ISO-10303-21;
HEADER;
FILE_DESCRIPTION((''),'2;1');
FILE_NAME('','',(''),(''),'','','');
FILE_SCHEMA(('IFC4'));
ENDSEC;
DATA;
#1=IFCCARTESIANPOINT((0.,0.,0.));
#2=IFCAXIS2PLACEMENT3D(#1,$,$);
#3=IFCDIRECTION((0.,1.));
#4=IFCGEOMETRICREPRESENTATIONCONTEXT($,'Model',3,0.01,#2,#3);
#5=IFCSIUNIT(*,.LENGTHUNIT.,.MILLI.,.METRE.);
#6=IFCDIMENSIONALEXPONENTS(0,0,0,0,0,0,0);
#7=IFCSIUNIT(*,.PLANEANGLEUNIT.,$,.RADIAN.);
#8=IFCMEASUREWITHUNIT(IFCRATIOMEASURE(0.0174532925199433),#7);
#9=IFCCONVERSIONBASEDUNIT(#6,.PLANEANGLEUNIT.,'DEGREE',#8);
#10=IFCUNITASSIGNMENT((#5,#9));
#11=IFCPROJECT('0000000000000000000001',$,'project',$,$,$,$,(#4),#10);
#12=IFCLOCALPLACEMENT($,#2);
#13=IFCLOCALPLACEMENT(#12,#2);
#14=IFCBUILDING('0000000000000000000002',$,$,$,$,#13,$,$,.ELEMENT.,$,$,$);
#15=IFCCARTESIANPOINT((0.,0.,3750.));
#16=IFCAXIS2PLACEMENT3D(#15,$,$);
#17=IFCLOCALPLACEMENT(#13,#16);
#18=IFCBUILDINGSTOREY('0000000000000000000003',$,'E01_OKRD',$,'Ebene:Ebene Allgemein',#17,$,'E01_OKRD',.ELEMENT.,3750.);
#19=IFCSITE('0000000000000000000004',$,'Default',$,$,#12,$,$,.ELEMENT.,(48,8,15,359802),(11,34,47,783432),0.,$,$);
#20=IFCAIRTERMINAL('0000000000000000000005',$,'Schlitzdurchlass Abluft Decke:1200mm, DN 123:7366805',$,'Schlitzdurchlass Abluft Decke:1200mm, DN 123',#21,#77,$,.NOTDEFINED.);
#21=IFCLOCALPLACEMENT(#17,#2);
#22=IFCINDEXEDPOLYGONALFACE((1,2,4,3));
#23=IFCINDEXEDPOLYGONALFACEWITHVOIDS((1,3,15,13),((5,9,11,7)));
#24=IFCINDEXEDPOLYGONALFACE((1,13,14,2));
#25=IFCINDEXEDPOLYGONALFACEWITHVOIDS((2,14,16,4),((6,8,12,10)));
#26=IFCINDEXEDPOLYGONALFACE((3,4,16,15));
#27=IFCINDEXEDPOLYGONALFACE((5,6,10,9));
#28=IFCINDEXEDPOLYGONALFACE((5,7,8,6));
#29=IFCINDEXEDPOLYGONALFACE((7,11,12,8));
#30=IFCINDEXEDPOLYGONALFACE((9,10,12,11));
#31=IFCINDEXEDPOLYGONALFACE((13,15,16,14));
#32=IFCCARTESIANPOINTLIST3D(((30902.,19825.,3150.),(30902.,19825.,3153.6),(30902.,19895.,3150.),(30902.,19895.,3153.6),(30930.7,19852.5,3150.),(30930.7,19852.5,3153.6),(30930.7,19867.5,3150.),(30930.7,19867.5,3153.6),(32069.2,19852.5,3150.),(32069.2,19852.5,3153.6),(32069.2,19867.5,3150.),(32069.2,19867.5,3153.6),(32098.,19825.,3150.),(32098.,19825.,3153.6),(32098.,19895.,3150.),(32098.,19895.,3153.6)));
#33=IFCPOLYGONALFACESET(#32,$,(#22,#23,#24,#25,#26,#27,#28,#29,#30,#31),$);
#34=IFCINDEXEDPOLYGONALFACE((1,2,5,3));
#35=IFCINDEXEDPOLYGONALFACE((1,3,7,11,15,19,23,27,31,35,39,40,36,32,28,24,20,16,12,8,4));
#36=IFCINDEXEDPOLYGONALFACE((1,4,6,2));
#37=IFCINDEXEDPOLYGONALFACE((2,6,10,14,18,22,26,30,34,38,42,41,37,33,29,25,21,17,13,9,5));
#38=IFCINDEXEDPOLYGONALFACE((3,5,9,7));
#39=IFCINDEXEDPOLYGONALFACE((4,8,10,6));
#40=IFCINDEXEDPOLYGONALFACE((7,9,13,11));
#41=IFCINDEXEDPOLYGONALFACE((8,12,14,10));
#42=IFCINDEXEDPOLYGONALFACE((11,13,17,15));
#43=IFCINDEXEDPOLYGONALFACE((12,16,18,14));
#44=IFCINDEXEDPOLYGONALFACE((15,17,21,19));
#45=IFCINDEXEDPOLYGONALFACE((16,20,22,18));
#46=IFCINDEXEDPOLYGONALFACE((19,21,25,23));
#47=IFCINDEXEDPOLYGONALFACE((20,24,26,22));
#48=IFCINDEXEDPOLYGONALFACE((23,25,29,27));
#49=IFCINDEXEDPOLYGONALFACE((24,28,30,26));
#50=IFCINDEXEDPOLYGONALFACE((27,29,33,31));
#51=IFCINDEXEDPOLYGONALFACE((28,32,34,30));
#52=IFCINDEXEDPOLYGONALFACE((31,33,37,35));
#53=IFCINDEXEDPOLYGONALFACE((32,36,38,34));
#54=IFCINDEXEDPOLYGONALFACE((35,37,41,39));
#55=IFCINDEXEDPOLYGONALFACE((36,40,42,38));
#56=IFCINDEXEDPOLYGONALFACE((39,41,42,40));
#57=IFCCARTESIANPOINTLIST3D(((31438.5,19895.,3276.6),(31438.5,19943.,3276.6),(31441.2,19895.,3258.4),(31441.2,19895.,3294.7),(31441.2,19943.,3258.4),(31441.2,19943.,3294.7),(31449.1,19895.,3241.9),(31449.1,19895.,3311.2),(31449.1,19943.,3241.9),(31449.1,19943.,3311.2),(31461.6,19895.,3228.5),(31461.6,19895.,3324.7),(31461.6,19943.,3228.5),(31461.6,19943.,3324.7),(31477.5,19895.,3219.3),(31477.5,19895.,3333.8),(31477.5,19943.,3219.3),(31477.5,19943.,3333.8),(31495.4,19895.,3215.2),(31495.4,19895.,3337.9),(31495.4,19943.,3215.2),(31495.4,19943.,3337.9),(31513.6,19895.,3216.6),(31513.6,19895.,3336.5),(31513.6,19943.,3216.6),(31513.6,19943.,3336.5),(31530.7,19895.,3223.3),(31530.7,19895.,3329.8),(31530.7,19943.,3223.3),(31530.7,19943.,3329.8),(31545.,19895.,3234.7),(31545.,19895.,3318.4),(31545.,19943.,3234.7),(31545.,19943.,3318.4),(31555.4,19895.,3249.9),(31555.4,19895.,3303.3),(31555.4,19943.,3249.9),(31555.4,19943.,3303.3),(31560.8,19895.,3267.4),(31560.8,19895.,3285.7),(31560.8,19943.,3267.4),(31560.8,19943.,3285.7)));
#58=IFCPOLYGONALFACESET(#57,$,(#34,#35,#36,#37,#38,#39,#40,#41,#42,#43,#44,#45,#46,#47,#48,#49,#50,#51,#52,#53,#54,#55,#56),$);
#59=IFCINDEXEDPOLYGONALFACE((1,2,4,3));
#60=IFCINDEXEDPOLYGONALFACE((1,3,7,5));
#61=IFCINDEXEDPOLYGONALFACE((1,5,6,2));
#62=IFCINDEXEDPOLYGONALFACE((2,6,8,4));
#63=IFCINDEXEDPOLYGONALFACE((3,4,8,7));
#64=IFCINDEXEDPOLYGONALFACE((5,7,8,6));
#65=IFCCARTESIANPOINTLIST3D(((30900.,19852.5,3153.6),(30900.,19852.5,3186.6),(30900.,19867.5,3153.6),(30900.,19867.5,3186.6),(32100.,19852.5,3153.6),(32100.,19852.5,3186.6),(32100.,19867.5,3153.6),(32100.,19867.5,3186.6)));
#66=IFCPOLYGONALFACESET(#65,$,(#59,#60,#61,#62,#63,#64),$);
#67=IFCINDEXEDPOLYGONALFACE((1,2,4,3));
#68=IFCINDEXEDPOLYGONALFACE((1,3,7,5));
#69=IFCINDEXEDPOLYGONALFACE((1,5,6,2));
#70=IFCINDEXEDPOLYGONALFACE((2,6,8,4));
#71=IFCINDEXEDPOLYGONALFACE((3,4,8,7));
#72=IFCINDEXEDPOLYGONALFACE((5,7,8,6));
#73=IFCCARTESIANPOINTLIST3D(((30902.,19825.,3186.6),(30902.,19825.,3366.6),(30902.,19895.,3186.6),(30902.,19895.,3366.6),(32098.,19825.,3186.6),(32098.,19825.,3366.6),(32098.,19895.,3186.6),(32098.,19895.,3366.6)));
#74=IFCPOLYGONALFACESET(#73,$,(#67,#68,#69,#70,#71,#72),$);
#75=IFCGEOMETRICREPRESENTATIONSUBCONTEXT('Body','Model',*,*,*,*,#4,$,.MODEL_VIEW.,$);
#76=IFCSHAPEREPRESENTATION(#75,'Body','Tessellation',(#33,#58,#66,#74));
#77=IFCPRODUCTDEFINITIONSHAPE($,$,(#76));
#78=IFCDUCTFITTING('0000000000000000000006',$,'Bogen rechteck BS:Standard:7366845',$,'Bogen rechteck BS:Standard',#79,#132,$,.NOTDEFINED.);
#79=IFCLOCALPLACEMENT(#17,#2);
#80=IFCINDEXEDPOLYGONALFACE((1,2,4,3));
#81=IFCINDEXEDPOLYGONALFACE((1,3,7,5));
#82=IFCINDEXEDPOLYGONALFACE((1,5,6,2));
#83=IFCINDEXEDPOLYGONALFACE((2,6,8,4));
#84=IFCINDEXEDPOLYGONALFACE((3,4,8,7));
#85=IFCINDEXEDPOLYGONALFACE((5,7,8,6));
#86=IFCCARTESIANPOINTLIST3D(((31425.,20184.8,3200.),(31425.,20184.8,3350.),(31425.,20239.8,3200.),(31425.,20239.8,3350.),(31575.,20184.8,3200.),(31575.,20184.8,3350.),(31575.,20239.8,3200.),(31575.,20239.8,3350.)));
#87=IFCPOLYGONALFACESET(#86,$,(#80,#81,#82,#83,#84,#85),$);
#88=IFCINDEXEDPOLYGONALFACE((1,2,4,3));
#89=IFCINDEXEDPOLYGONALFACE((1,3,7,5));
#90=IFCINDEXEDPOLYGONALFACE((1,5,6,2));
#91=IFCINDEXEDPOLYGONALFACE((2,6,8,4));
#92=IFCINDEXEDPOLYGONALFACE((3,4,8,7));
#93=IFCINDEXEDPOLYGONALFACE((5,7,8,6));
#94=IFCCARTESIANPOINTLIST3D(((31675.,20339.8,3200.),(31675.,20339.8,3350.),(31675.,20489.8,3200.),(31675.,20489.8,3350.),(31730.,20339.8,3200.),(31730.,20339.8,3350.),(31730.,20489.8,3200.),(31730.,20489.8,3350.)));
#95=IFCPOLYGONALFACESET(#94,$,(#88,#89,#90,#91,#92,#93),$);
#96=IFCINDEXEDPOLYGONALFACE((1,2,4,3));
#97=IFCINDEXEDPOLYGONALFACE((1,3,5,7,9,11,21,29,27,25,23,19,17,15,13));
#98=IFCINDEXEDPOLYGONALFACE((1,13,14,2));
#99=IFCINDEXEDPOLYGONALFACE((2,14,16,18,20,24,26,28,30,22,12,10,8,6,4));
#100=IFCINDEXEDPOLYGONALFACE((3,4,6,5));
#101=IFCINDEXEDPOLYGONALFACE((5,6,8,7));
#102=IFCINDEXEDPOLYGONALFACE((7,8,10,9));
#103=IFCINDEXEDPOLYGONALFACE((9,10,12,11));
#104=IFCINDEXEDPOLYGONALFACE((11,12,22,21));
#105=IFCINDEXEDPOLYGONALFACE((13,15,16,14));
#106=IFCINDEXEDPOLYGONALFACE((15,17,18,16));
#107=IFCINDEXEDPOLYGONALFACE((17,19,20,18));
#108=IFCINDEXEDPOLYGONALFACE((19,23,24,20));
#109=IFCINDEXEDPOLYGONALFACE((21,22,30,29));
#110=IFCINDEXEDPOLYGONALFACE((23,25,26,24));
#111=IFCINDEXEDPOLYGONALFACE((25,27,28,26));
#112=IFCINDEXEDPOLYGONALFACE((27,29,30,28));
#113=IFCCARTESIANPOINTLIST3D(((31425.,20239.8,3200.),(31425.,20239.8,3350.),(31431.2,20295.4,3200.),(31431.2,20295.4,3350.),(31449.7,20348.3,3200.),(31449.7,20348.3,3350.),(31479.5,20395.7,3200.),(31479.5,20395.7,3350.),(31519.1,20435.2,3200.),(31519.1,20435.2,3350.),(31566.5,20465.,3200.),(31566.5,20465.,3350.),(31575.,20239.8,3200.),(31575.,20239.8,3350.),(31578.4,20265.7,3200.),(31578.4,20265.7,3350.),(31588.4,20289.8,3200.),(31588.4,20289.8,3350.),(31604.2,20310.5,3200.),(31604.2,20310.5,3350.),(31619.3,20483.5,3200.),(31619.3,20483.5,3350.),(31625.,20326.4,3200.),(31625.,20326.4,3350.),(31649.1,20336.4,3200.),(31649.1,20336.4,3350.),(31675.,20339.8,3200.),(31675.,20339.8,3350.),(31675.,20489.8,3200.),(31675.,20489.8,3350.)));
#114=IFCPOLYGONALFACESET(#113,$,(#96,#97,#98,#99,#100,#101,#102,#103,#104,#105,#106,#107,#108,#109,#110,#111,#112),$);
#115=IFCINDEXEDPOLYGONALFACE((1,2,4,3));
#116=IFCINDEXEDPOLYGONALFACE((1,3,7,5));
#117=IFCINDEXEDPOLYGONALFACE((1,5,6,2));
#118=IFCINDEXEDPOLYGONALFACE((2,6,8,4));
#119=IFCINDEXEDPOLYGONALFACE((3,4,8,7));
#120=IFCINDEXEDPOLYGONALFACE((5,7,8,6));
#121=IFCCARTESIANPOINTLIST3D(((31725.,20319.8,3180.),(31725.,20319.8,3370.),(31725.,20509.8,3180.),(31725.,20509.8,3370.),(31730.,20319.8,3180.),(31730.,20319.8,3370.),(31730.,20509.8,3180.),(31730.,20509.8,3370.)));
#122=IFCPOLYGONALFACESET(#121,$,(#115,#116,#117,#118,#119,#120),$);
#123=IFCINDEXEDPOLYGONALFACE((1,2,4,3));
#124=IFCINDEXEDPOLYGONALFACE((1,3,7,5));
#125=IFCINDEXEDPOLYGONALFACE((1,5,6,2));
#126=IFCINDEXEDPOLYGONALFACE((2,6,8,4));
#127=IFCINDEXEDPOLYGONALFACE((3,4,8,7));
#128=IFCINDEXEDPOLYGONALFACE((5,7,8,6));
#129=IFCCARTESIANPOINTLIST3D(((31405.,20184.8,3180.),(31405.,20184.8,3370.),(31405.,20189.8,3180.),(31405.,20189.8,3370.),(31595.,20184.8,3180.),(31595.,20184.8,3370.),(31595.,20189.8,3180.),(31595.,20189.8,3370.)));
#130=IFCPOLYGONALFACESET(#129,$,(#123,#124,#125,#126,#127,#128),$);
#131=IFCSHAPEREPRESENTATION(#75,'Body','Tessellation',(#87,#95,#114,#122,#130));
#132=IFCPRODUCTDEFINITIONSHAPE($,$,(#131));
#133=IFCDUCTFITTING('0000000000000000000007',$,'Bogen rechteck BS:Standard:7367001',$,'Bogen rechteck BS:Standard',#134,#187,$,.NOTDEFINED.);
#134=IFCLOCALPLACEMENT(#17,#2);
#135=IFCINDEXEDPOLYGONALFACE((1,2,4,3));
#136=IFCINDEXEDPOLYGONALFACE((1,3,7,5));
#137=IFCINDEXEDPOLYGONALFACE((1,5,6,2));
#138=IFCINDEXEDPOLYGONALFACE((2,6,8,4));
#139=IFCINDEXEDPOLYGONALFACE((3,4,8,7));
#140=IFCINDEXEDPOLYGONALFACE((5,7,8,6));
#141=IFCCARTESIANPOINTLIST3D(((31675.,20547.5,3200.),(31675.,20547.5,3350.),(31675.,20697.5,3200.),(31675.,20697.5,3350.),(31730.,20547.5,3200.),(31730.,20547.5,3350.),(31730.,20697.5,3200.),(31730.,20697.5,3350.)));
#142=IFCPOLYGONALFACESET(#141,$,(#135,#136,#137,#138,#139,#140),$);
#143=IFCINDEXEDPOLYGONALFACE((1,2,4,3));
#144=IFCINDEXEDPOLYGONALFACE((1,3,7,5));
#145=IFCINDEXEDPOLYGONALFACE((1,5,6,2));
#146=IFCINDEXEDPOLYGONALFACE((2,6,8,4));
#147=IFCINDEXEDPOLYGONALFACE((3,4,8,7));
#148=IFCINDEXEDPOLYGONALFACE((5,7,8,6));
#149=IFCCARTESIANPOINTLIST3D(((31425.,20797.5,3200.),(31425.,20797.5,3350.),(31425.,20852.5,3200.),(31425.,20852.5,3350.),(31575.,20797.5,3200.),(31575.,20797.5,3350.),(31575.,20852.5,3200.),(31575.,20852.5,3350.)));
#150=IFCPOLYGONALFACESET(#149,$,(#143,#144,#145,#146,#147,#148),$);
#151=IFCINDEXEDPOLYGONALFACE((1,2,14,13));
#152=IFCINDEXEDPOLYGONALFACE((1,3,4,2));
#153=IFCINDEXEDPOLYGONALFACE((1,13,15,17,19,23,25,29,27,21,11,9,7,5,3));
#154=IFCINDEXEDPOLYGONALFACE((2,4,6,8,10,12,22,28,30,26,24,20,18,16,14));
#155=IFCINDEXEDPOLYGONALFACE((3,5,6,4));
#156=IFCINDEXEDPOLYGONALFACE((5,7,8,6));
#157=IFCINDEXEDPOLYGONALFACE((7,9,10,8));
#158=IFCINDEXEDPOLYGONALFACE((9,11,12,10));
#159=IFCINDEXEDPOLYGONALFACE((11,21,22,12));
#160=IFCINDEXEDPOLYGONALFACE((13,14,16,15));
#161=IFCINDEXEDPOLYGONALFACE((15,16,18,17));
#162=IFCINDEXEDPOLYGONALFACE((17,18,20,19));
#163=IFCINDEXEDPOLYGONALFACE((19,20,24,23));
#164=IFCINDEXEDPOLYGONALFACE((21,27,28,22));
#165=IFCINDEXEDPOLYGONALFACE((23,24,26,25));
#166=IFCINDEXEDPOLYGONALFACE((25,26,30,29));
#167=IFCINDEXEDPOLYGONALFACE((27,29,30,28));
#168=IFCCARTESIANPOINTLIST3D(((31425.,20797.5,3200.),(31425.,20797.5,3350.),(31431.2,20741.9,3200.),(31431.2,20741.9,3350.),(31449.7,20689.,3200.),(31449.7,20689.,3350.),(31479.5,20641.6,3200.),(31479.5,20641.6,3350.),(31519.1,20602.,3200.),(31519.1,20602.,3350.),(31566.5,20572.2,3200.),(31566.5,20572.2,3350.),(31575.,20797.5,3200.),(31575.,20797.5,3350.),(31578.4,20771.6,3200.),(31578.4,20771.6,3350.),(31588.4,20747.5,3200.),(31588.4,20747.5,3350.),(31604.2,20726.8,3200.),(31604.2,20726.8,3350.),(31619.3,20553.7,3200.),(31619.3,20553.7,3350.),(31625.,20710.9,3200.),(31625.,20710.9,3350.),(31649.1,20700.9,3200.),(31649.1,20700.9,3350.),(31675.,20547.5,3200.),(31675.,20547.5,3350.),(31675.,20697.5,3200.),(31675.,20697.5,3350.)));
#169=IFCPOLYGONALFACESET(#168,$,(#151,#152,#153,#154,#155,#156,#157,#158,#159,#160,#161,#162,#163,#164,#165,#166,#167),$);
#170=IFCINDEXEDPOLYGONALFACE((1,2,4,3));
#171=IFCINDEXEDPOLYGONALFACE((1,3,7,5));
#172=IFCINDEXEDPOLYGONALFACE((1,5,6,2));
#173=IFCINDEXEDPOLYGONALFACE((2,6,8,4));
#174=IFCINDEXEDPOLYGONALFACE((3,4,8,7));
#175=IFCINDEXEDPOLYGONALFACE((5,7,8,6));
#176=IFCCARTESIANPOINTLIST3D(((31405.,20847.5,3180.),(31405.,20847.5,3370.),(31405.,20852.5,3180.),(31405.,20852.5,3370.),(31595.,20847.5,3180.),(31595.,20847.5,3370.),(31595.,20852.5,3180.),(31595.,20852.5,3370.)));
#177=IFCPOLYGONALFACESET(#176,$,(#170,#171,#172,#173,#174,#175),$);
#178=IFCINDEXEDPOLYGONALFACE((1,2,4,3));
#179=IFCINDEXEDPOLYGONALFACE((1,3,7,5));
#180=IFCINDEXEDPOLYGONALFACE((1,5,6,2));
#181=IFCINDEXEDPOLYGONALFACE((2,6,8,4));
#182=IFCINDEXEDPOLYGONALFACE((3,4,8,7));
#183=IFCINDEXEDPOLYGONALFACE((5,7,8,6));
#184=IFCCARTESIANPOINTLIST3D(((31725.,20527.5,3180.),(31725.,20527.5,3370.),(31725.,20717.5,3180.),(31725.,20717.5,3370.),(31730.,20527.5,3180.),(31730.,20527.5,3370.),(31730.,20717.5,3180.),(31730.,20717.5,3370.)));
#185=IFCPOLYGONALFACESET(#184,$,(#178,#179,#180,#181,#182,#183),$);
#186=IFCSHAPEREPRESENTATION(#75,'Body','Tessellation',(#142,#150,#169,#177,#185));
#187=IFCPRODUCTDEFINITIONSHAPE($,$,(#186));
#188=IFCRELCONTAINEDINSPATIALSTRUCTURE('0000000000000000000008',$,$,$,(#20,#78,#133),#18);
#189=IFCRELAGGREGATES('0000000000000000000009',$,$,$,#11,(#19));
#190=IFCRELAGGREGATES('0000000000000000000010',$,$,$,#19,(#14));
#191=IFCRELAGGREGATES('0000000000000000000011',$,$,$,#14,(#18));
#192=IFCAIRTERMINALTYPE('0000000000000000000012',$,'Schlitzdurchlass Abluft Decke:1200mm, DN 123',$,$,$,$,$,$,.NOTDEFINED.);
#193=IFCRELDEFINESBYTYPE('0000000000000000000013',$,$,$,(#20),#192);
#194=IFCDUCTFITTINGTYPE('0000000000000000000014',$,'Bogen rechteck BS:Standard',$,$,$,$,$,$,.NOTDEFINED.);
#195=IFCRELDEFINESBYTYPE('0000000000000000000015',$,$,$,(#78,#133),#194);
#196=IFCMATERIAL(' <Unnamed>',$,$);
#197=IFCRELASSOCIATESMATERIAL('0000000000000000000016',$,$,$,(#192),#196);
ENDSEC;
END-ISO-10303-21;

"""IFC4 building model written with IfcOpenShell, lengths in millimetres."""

from ifc_helpers import new_model, entity, si_unit, converted_unit, direction, frame, frame_2d, origin, origin_2d_with_axis, place, context, subcontext, project, spatial, polyline, circle_curve, parameter, trimmed, segment, composite_curve, rectangle, circle, outline, extrude, source, transform, mapped, material, type_object, type_shapes, element, save


model = new_model("IFC4")

# Units and contexts
model_context = context("Model", 3, precision=0.01, world=origin(), true_north=direction((0.0, 1.0)))
body_context = subcontext(model_context, "Body", "Model", "MODEL_VIEW")
ifc_project = project(units=[si_unit("LENGTHUNIT", "METRE", prefix="MILLI"), converted_unit("PLANEANGLEUNIT", "DEGREE", entity("IfcRatioMeasure", 0.0174532925199433), si_unit("PLANEANGLEUNIT", "RADIAN"), dimensions=[0, 0, 0, 0, 0, 0, 0])], contexts=[model_context])

# Site, building, storey
site_placement = place(None, origin())
site = spatial("IfcSite", under=ifc_project, at=site_placement, Name="Default", CompositionType="ELEMENT", RefLatitude=(48, 8, 15, 359802), RefLongitude=(11, 34, 47, 783432), RefElevation=0.0)
building_placement = place(site_placement, origin())
building = spatial("IfcBuilding", under=site, at=building_placement, CompositionType="ELEMENT")
storey_placement = place(building_placement, frame((0.0, 0.0, 3750.0)))
storey = spatial("IfcBuildingStorey", under=building, at=storey_placement, Name="E01_OKRD", ObjectType="Ebene:Ebene Allgemein", LongName="E01_OKRD", CompositionType="ELEMENT", Elevation=3750.0)

# Shared definitions
ifc_material_1 = material(Name=" <Unnamed>")

# Air terminal
air_terminal_type_1 = type_object("IfcAirTerminalType", Name="Schlitzdurchlass Abluft Decke:1200mm, DN 123", PredefinedType="NOTDEFINED", material=ifc_material_1)
shared_shape_1 = source(origin(), body_context, "Body", "SweptSolid", [
    extrude(outline(polyline([(-598.0, -35.0), (598.0, -35.0), (598.0, 35.0), (-598.0, 35.0), (-598.0, -35.0)]), holes=[polyline([(-569.2, -7.5), (-569.2, 7.5), (569.2, 7.5), (569.2, -7.5), (-569.2, -7.5)])]), frame((0.0, 0.0, 0.0), z_axis=(0.0, 0.0, 1.0), x_axis=(-1.0, 0.0, 0.0)), (0.0, 0.0, 1.0), 3.6),
    extrude(circle(Radius=61.5, at=frame_2d((0.0, 0.0), x_axis=(1.0, 0.0))), frame((0.0, 35.0, 126.6), z_axis=(0.0, 1.0, 0.0), x_axis=(-1.0, 0.0, 0.0)), (0.0, 0.0, 1.0), 48.0),
    extrude(rectangle(XDim=1200.0, YDim=15.0, at=origin_2d_with_axis()), frame((0.0, 0.0, 3.6), z_axis=(0.0, 0.0, 1.0), x_axis=(-1.0, 0.0, 0.0)), (0.0, 0.0, 1.0), 33.0),
    extrude(rectangle(XDim=1196.0, YDim=70.0, at=origin_2d_with_axis()), frame((0.0, 0.0, 36.6), z_axis=(0.0, 0.0, 1.0), x_axis=(-1.0, 0.0, 0.0)), (0.0, 0.0, 1.0), 180.0),
])
type_shapes(air_terminal_type_1, [shared_shape_1])
air_terminal_1_placement = place(storey_placement, frame((31500.0, 19860.0, 3150.0)))
element("IfcAirTerminal", 1, at=air_terminal_1_placement, inside=storey, type_object=air_terminal_type_1, Name="Schlitzdurchlass Abluft Decke:1200mm, DN 123:7366805", ObjectType="Schlitzdurchlass Abluft Decke:1200mm, DN 123", PredefinedType="NOTDEFINED", context=body_context, shape_type="MappedRepresentation", body=[
    mapped(shared_shape_1, transform((0.0, 0.0, 0.0), scale=1.0)),
])

# Duct fittings
duct_fitting_type_1 = type_object("IfcDuctFittingType", Name="Bogen rechteck BS:Standard", PredefinedType="NOTDEFINED")
shared_shape_2 = source(origin(), body_context, "Body", "SweptSolid", [
    extrude(rectangle(XDim=55.0, YDim=150.0, at=origin_2d_with_axis()), frame((0.0, 202.5, -75.0), z_axis=(0.0, 0.0, 1.0), x_axis=(0.0, 1.0, 0.0)), (0.0, 0.0, 1.0), 150.0),
    extrude(rectangle(XDim=150.0, YDim=55.0, at=frame_2d((0.0, 0.0), x_axis=(1.0, 0.0))), frame((-202.5, 0.0, -75.0), z_axis=(0.0, 0.0, 1.0), x_axis=(0.0, -1.0, 0.0)), (0.0, 0.0, 1.0), 150.0),
    extrude(outline(composite_curve([segment(polyline([(-162.5, -87.5), (-12.5, -87.5)]), True, "CONTINUOUS"), segment(trimmed(circle_curve(frame_2d((87.5, -87.5), x_axis=(0.0, 1.0)), 100.0), [parameter(0.0)], [parameter(90.0)], True, "PARAMETER"), False, "CONTINUOUS"), segment(polyline([(87.5, 12.5), (87.5, 162.5)]), True, "CONTINUOUS"), segment(trimmed(circle_curve(frame_2d((87.5, -87.5), x_axis=(0.0, 1.0)), 250.0), [parameter(0.0)], [parameter(90.0)], True, "PARAMETER"), True, "CONTINUOUS")], self_intersect=False)), frame((-87.5, 87.5, -75.0), z_axis=(0.0, 0.0, 1.0), x_axis=(-1.0, 0.0, 0.0)), (0.0, 0.0, 1.0), 150.0),
    extrude(rectangle(XDim=5.0, YDim=190.0, at=frame_2d((0.0, 0.0), x_axis=(1.0, 0.0))), frame((-227.5, 0.0, -95.0)), (0.0, 0.0, 1.0), 190.0),
    extrude(rectangle(XDim=5.0, YDim=190.0, at=frame_2d((0.0, 0.0), x_axis=(1.0, 0.0))), frame((0.0, 227.5, -95.0), z_axis=(0.0, 0.0, 1.0), x_axis=(0.0, 1.0, 0.0)), (0.0, 0.0, 1.0), 190.0),
])
type_shapes(duct_fitting_type_1, [shared_shape_2])
for number, where, z_axis, x_axis, name in (
    (2, (31500.0, 20414.8, 3275.0), (0.0, 0.0, 1.0), (-1.0, 0.0, 0.0), "Bogen rechteck BS:Standard:7366845"),
    (3, (31500.0, 20622.5, 3275.0), (0.0, 0.0, 1.0), (0.0, -1.0, 0.0), "Bogen rechteck BS:Standard:7367001"),
):
    element("IfcDuctFitting", number, at=place(storey_placement, frame(where, z_axis=z_axis, x_axis=x_axis)), inside=storey, type_object=duct_fitting_type_1, Name=name, ObjectType="Bogen rechteck BS:Standard", PredefinedType="NOTDEFINED", context=body_context, shape_type="MappedRepresentation", body=[
        mapped(shared_shape_2, transform((0.0, 0.0, 0.0), scale=1.0)),
    ])

save(model, "model.ifc")
